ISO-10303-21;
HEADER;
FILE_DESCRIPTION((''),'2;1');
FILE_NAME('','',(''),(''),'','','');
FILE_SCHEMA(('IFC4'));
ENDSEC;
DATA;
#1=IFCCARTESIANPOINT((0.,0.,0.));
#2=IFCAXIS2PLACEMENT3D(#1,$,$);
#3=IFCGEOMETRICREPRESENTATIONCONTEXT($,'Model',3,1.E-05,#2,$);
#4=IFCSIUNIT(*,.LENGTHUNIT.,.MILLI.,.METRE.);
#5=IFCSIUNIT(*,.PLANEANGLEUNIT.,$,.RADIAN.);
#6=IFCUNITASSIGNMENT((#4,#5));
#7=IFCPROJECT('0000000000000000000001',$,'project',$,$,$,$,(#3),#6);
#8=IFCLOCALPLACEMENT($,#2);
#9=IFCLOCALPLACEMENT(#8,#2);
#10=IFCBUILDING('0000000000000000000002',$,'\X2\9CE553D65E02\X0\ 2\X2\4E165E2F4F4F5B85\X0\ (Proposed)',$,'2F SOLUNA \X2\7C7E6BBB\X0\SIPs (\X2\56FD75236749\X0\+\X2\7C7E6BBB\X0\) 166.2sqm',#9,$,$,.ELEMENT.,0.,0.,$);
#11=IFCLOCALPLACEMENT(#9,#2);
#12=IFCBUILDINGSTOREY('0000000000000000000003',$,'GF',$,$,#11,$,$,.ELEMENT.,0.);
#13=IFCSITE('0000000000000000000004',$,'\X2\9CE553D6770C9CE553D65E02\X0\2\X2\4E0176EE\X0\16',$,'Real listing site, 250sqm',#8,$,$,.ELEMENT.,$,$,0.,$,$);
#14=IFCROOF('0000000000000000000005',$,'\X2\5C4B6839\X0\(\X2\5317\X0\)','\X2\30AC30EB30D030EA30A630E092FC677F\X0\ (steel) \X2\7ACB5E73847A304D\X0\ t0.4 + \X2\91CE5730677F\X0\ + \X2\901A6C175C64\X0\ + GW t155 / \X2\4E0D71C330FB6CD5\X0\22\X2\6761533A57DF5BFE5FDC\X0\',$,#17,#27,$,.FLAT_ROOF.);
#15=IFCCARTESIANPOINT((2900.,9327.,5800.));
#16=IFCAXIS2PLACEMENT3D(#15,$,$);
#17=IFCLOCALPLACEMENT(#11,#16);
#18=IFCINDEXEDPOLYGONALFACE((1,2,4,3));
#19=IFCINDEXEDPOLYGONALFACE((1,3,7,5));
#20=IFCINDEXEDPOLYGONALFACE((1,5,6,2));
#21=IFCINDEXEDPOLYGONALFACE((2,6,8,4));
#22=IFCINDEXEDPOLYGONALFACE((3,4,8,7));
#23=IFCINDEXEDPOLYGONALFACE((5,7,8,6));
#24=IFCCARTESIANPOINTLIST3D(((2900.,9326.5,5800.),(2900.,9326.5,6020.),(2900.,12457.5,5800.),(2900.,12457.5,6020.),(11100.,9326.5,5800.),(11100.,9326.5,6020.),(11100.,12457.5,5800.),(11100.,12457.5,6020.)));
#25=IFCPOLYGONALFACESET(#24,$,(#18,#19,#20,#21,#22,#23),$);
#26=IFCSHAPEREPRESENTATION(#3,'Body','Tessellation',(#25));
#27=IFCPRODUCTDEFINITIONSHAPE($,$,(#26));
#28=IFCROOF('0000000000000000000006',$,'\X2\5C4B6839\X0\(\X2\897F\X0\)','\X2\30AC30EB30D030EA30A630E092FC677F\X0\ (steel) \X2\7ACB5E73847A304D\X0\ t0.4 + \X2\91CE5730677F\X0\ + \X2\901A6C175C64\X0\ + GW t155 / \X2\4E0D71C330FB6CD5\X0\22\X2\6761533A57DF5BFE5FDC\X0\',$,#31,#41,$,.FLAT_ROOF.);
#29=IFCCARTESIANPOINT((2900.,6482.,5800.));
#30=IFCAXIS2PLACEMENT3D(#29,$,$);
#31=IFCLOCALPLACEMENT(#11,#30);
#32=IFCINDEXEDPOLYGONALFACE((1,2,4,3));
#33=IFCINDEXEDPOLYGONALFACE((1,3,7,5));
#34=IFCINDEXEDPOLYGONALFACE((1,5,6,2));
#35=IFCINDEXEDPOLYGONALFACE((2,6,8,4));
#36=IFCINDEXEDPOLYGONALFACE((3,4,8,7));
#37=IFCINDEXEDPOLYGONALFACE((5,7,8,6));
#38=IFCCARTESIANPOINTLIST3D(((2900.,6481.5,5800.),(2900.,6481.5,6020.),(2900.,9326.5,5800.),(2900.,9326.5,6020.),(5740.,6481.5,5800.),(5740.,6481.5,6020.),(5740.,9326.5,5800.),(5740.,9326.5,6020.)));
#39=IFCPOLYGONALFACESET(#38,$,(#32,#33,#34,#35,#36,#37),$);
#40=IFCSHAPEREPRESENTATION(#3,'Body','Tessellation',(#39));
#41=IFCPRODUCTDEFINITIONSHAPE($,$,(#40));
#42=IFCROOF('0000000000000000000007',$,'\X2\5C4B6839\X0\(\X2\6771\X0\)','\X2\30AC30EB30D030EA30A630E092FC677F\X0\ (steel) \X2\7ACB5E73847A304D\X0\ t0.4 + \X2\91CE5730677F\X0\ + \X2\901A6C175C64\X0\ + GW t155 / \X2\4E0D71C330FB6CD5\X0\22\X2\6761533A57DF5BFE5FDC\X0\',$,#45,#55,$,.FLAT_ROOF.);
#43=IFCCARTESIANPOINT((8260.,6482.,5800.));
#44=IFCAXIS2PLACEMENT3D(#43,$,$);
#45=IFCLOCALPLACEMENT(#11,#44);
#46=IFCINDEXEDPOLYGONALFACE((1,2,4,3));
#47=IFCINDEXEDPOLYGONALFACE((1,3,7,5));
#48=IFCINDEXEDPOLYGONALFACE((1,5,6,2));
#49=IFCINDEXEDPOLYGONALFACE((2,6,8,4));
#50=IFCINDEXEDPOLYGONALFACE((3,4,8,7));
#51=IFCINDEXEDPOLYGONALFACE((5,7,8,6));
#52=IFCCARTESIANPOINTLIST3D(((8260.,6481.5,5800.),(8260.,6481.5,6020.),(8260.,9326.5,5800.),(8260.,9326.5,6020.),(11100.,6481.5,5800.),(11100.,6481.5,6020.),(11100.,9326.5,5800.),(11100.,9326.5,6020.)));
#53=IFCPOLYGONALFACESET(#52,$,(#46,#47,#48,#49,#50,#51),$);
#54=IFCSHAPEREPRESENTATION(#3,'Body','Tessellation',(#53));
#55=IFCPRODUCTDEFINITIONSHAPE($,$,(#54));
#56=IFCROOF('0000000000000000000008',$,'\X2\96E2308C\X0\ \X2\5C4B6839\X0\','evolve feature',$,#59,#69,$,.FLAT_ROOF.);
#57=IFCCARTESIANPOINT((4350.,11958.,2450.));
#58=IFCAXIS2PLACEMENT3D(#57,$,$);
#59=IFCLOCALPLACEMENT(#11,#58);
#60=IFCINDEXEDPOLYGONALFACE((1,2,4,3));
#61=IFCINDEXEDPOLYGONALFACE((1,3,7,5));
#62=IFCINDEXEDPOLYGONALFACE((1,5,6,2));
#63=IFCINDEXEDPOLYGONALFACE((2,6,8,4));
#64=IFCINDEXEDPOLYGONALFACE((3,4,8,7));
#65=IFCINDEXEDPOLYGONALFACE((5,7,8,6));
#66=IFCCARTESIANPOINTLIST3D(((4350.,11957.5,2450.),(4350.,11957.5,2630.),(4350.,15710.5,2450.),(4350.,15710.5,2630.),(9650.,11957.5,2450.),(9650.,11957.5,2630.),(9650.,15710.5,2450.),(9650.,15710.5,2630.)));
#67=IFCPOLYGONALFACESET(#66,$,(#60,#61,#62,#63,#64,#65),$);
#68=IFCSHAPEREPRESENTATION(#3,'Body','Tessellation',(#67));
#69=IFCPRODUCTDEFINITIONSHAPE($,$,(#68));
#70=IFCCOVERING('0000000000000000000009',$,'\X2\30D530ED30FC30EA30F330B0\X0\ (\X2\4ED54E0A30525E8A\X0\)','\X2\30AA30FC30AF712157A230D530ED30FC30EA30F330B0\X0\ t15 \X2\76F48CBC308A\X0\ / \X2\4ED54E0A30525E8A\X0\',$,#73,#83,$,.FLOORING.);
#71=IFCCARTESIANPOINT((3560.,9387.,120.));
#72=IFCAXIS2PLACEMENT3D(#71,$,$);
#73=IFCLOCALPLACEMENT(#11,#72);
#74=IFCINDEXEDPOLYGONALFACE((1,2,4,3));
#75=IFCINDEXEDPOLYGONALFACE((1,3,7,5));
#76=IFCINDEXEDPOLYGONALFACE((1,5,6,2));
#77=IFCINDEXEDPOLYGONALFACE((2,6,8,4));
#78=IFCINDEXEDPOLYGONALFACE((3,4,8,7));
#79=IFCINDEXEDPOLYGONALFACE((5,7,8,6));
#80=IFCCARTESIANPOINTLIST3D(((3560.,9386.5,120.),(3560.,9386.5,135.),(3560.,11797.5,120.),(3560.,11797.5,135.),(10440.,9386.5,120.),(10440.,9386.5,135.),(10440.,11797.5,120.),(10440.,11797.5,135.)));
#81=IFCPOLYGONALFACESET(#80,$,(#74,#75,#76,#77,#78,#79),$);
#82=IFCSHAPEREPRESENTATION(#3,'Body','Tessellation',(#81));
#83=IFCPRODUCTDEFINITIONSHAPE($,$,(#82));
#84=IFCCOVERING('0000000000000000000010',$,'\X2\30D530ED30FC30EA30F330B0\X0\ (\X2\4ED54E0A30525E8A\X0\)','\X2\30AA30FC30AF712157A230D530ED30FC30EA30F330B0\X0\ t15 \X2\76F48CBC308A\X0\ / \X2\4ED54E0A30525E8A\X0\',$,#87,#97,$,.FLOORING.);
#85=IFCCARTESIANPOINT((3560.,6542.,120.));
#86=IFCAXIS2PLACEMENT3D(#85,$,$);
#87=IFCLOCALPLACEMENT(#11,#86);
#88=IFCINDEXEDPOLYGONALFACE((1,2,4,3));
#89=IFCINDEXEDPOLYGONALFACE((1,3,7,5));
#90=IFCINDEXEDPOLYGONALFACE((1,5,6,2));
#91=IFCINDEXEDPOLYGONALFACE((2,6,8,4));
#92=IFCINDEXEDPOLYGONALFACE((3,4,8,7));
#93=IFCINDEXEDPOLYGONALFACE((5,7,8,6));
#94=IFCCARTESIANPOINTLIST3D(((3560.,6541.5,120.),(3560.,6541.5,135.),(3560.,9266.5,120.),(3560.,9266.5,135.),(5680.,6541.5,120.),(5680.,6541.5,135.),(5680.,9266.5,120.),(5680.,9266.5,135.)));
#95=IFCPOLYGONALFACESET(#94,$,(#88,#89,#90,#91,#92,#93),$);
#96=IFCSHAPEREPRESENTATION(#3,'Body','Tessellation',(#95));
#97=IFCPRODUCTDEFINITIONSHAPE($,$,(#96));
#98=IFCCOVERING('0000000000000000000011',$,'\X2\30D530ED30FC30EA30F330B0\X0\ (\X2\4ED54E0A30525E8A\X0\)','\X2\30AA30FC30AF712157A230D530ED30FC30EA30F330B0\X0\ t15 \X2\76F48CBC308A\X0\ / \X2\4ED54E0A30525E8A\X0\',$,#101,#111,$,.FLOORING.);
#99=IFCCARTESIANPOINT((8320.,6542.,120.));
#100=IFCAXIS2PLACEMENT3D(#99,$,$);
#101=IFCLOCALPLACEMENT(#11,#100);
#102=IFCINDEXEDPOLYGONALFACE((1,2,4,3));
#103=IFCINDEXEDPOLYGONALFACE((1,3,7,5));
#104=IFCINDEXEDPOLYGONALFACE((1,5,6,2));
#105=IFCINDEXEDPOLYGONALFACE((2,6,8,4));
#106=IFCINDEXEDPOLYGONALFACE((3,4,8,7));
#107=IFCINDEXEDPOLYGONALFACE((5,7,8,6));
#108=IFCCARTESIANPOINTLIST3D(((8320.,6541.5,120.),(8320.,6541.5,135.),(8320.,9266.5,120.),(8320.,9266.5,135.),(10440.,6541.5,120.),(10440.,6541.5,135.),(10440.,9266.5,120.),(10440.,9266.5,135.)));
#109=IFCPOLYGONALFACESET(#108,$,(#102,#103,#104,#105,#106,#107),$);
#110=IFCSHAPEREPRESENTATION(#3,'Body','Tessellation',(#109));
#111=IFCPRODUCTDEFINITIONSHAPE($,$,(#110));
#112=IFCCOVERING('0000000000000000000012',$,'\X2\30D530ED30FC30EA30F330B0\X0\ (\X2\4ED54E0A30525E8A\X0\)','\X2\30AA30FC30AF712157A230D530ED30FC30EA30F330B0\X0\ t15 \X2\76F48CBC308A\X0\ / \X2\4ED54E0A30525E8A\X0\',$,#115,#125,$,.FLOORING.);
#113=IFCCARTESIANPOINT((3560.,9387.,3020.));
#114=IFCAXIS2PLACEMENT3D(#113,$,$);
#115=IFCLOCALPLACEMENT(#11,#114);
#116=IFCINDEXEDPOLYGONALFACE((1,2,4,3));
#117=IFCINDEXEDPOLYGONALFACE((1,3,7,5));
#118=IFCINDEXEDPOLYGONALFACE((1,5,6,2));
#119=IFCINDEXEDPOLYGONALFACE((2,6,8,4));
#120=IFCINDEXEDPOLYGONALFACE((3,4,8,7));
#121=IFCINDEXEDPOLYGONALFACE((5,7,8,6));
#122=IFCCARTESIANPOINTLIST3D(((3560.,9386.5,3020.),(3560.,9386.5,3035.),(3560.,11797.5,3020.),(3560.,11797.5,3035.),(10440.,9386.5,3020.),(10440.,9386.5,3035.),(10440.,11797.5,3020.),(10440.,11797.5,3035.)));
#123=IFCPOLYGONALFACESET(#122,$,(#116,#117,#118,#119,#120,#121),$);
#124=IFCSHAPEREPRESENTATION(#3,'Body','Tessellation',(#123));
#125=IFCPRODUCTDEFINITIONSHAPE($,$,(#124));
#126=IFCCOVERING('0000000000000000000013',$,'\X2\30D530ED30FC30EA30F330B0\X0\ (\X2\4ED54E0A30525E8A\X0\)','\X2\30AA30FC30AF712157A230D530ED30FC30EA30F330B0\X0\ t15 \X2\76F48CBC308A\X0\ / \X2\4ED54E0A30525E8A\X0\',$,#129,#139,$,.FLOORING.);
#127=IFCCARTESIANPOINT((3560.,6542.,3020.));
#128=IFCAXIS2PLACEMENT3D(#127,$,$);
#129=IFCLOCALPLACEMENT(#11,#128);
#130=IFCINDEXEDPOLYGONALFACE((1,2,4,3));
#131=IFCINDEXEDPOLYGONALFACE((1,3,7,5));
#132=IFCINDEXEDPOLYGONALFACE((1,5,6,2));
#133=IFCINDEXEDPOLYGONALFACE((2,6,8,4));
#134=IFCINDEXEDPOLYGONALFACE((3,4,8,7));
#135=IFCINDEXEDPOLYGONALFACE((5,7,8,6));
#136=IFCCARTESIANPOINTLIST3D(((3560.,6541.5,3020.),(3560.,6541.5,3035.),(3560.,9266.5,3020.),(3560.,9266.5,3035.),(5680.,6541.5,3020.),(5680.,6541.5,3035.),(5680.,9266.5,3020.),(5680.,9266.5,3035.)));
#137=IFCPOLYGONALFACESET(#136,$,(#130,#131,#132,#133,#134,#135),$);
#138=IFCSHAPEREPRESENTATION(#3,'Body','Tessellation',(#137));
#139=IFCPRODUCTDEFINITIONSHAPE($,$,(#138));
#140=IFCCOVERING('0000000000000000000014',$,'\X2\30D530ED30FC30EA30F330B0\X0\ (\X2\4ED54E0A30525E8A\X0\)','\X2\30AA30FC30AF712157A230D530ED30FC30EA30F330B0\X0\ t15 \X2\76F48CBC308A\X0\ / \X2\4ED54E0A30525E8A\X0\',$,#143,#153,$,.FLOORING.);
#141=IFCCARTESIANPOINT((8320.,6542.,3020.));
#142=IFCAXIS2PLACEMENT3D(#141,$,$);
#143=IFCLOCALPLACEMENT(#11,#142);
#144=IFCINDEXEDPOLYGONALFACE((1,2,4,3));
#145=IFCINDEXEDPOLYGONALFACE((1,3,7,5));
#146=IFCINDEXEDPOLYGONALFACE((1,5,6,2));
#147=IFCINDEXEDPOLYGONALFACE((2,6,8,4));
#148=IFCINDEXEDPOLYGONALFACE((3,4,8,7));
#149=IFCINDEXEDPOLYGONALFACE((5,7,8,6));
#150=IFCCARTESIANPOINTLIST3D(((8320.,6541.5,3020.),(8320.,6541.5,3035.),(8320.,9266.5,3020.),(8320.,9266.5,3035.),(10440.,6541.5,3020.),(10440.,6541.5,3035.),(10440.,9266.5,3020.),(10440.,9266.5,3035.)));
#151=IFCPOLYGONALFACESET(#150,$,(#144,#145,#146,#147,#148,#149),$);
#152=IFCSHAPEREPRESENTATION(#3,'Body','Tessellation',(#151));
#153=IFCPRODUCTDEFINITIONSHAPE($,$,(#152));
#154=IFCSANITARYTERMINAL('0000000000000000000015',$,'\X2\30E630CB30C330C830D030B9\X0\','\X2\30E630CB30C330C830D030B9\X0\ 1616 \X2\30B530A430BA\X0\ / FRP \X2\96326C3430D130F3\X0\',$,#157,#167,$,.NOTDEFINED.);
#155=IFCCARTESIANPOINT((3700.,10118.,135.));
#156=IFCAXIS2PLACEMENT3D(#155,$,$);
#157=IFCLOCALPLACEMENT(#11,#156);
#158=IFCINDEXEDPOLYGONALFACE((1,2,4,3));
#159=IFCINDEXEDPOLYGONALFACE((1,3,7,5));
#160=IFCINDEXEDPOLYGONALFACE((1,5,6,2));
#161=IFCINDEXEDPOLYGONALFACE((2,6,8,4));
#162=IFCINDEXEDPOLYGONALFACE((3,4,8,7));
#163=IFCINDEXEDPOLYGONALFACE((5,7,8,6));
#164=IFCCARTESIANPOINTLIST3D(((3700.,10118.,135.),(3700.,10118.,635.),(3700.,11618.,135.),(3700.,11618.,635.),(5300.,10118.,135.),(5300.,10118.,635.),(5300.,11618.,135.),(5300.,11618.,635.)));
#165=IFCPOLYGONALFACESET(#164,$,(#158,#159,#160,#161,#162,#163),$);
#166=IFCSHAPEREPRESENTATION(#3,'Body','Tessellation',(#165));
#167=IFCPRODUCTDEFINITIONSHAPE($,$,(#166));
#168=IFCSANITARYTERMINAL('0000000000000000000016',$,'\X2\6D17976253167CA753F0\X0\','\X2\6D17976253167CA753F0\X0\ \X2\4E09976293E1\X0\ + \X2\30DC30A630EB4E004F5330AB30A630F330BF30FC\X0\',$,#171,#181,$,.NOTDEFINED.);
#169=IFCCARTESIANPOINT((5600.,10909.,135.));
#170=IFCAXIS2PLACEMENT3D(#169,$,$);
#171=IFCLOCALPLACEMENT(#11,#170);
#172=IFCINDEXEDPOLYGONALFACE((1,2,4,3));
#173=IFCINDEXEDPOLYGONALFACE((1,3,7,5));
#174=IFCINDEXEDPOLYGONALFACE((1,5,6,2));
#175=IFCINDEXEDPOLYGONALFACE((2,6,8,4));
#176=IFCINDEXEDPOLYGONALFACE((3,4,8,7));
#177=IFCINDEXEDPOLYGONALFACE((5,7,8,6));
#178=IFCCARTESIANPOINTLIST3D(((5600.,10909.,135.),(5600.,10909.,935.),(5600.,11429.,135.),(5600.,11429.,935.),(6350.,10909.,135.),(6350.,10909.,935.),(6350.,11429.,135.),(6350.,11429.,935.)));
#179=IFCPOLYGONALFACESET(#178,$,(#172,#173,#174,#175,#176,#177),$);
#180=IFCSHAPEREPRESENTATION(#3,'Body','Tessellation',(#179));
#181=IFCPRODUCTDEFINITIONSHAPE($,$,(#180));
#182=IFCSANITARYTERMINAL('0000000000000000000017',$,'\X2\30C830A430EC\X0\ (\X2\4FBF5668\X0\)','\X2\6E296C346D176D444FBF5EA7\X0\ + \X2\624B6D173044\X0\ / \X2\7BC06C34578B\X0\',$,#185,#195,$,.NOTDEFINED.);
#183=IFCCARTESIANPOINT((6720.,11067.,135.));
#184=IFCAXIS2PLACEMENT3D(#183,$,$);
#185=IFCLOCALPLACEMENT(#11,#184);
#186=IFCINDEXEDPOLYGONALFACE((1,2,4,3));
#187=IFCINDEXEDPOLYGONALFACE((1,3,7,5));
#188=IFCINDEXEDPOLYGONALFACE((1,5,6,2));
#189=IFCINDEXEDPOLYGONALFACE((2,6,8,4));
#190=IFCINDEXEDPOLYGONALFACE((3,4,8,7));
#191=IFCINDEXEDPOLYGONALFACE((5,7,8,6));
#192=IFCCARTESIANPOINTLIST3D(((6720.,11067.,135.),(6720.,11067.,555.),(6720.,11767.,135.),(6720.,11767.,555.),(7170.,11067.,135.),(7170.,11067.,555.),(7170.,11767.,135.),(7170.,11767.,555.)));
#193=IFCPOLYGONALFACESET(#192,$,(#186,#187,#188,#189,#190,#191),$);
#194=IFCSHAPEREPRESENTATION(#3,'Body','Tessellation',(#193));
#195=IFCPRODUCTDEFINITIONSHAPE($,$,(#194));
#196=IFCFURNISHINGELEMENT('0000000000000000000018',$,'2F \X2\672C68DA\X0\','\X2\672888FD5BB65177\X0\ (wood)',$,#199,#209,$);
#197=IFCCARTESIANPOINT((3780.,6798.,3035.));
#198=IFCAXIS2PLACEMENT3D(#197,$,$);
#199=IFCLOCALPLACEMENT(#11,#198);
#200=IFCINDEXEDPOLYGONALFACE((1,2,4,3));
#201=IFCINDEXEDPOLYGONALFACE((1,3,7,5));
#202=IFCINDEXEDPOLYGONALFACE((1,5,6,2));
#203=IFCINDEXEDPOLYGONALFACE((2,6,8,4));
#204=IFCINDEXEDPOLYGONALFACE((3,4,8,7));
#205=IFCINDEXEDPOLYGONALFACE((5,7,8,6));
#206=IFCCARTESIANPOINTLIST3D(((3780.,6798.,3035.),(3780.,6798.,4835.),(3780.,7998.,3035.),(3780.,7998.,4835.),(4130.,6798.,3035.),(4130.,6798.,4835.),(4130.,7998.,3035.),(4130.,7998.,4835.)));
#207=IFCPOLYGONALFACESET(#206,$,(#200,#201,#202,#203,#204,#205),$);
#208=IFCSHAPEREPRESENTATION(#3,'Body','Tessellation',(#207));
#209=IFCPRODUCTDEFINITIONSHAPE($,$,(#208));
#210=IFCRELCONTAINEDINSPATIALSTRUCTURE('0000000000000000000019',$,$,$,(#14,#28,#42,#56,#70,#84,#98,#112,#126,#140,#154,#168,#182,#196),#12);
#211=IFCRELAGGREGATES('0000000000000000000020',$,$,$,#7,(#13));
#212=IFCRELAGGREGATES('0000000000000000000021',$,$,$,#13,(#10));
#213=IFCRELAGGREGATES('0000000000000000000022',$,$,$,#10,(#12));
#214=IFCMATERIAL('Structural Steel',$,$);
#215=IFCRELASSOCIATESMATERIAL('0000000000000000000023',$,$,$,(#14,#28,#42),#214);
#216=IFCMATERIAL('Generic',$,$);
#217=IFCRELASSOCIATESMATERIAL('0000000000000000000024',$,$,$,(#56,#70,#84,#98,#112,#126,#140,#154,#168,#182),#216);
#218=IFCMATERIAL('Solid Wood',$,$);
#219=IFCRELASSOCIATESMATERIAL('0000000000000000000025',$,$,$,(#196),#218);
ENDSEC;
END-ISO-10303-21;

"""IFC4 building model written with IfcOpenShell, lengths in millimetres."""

from ifc_helpers import new_model, si_unit, frame, frame_2d, origin, place, context, project, spatial, rectangle, extrude, material, element, save


model = new_model("IFC4")

# Units and contexts
model_context = context("Model", 3, precision=1e-05, world=origin())
ifc_project = project(units=[si_unit("LENGTHUNIT", "METRE", prefix="MILLI"), si_unit("PLANEANGLEUNIT", "RADIAN")], contexts=[model_context])

# Site, building, storey
site_placement = place(None, origin())
site = spatial("IfcSite", under=ifc_project, at=site_placement, Name="鳥取県鳥取市2丁目16", ObjectType="Real listing site, 250sqm", CompositionType="ELEMENT", RefElevation=0.0)
building_placement = place(site_placement, origin())
building = spatial("IfcBuilding", under=site, at=building_placement, Name="鳥取市 2世帯住宅 (Proposed)", ObjectType="2F SOLUNA 籾殻SIPs (国産杉+籾殻) 166.2sqm", CompositionType="ELEMENT", ElevationOfRefHeight=0.0, ElevationOfTerrain=0.0)
storey_placement = place(building_placement, origin())
storey = spatial("IfcBuildingStorey", under=building, at=storey_placement, Name="GF", CompositionType="ELEMENT", Elevation=0.0)

# Shared definitions
ifc_material_1 = material(Name="Solid Wood")
ifc_material_2 = material(Name="Generic")

# Roofs
ifc_material_3 = material(Name="Structural Steel")
for number, where, name in (
    (1, (2900.0, 9327.0, 5800.0), "屋根(北)"),
):
    element("IfcRoof", number, at=place(storey_placement, frame(where)), inside=storey, material=ifc_material_3, Name=name, Description="ガルバリウム鋼板 (steel) 立平葺き t0.4 + 野地板 + 通気層 + GW t155 / 不燃・法22条区域対応", PredefinedType="FLAT_ROOF", context=model_context, shape_type="SweptSolid", body=[
        extrude(rectangle(XDim=8200.0, YDim=3131.0, at=frame_2d((4100.0, 1565.0))), frame((2900.0, 9327.0, 5800.0)), (0.0, 0.0, 1.0), 220.0),
    ])
roof_1_placement = place(storey_placement, frame((2900.0, 6482.0, 5800.0)))
element("IfcRoof", 2, at=roof_1_placement, inside=storey, material=ifc_material_3, Name="屋根(西)", Description="ガルバリウム鋼板 (steel) 立平葺き t0.4 + 野地板 + 通気層 + GW t155 / 不燃・法22条区域対応", PredefinedType="FLAT_ROOF", context=model_context, shape_type="SweptSolid", body=[
    extrude(rectangle(XDim=2840.0, YDim=2845.0, at=frame_2d((1420.0, 1422.0))), frame((2900.0, 6482.0, 5800.0)), (0.0, 0.0, 1.0), 220.0),
])
roof_2_placement = place(storey_placement, frame((8260.0, 6482.0, 5800.0)))
element("IfcRoof", 3, at=roof_2_placement, inside=storey, material=ifc_material_3, Name="屋根(東)", Description="ガルバリウム鋼板 (steel) 立平葺き t0.4 + 野地板 + 通気層 + GW t155 / 不燃・法22条区域対応", PredefinedType="FLAT_ROOF", context=model_context, shape_type="SweptSolid", body=[
    extrude(rectangle(XDim=2840.0, YDim=2845.0, at=frame_2d((1420.0, 1422.0))), frame((8260.0, 6482.0, 5800.0)), (0.0, 0.0, 1.0), 220.0),
])
roof_3_placement = place(storey_placement, frame((4350.0, 11958.0, 2450.0)))
element("IfcRoof", 4, at=roof_3_placement, inside=storey, material=ifc_material_2, Name="離れ 屋根", Description="evolve feature", PredefinedType="FLAT_ROOF", context=model_context, shape_type="SweptSolid", body=[
    extrude(rectangle(XDim=5300.0, YDim=3753.0, at=frame_2d((2650.0, 1876.0))), frame((4350.0, 11958.0, 2450.0)), (0.0, 0.0, 1.0), 180.0),
])

# Coverings
covering_1_placement = place(storey_placement, frame((3560.0, 9387.0, 120.0)))
element("IfcCovering", 5, at=covering_1_placement, inside=storey, material=ifc_material_2, Name="フローリング (仕上げ床)", Description="オーク無垢フローリング t15 直貼り / 仕上げ床", PredefinedType="FLOORING", context=model_context, shape_type="SweptSolid", body=[
    extrude(rectangle(XDim=6880.0, YDim=2411.0, at=frame_2d((3440.0, 1205.0))), frame((3560.0, 9387.0, 120.0)), (0.0, 0.0, 1.0), 15.0),
])
covering_2_placement = place(storey_placement, frame((3560.0, 6542.0, 120.0)))
element("IfcCovering", 6, at=covering_2_placement, inside=storey, material=ifc_material_2, Name="フローリング (仕上げ床)", Description="オーク無垢フローリング t15 直貼り / 仕上げ床", PredefinedType="FLOORING", context=model_context, shape_type="SweptSolid", body=[
    extrude(rectangle(XDim=2120.0, YDim=2725.0, at=frame_2d((1060.0, 1362.0))), frame((3560.0, 6542.0, 120.0)), (0.0, 0.0, 1.0), 15.0),
])
covering_3_placement = place(storey_placement, frame((8320.0, 6542.0, 120.0)))
element("IfcCovering", 7, at=covering_3_placement, inside=storey, material=ifc_material_2, Name="フローリング (仕上げ床)", Description="オーク無垢フローリング t15 直貼り / 仕上げ床", PredefinedType="FLOORING", context=model_context, shape_type="SweptSolid", body=[
    extrude(rectangle(XDim=2120.0, YDim=2725.0, at=frame_2d((1060.0, 1362.0))), frame((8320.0, 6542.0, 120.0)), (0.0, 0.0, 1.0), 15.0),
])
covering_4_placement = place(storey_placement, frame((3560.0, 9387.0, 3020.0)))
element("IfcCovering", 8, at=covering_4_placement, inside=storey, material=ifc_material_2, Name="フローリング (仕上げ床)", Description="オーク無垢フローリング t15 直貼り / 仕上げ床", PredefinedType="FLOORING", context=model_context, shape_type="SweptSolid", body=[
    extrude(rectangle(XDim=6880.0, YDim=2411.0, at=frame_2d((3440.0, 1205.0))), frame((3560.0, 9387.0, 3020.0)), (0.0, 0.0, 1.0), 15.0),
])
covering_5_placement = place(storey_placement, frame((3560.0, 6542.0, 3020.0)))
element("IfcCovering", 9, at=covering_5_placement, inside=storey, material=ifc_material_2, Name="フローリング (仕上げ床)", Description="オーク無垢フローリング t15 直貼り / 仕上げ床", PredefinedType="FLOORING", context=model_context, shape_type="SweptSolid", body=[
    extrude(rectangle(XDim=2120.0, YDim=2725.0, at=frame_2d((1060.0, 1362.0))), frame((3560.0, 6542.0, 3020.0)), (0.0, 0.0, 1.0), 15.0),
])
covering_6_placement = place(storey_placement, frame((8320.0, 6542.0, 3020.0)))
element("IfcCovering", 10, at=covering_6_placement, inside=storey, material=ifc_material_2, Name="フローリング (仕上げ床)", Description="オーク無垢フローリング t15 直貼り / 仕上げ床", PredefinedType="FLOORING", context=model_context, shape_type="SweptSolid", body=[
    extrude(rectangle(XDim=2120.0, YDim=2725.0, at=frame_2d((1060.0, 1362.0))), frame((8320.0, 6542.0, 3020.0)), (0.0, 0.0, 1.0), 15.0),
])

# Sanitary terminals
sanitary_terminal_1_placement = place(storey_placement, frame((3700.0, 10118.0, 135.0)))
element("IfcSanitaryTerminal", 11, at=sanitary_terminal_1_placement, inside=storey, material=ifc_material_2, Name="ユニットバス", Description="ユニットバス 1616 サイズ / FRP 防水パン", PredefinedType="NOTDEFINED", context=model_context, shape_type="SweptSolid", body=[
    extrude(rectangle(XDim=1600.0, YDim=1500.0, at=frame_2d((800.0, 750.0))), frame((3700.0, 10118.0, 135.0)), (0.0, 0.0, 1.0), 500.0),
])
sanitary_terminal_2_placement = place(storey_placement, frame((5600.0, 10909.0, 135.0)))
element("IfcSanitaryTerminal", 12, at=sanitary_terminal_2_placement, inside=storey, material=ifc_material_2, Name="洗面化粧台", Description="洗面化粧台 三面鏡 + ボウル一体カウンター", PredefinedType="NOTDEFINED", context=model_context, shape_type="SweptSolid", body=[
    extrude(rectangle(XDim=750.0, YDim=520.0, at=frame_2d((375.0, 260.0))), frame((5600.0, 10909.0, 135.0)), (0.0, 0.0, 1.0), 800.0),
])
sanitary_terminal_3_placement = place(storey_placement, frame((6720.0, 11067.0, 135.0)))
element("IfcSanitaryTerminal", 13, at=sanitary_terminal_3_placement, inside=storey, material=ifc_material_2, Name="トイレ (便器)", Description="温水洗浄便座 + 手洗い / 節水型", PredefinedType="NOTDEFINED", context=model_context, shape_type="SweptSolid", body=[
    extrude(rectangle(XDim=450.0, YDim=700.0, at=frame_2d((225.0, 350.0))), frame((6720.0, 11067.0, 135.0)), (0.0, 0.0, 1.0), 420.0),
])

# Furnishing element
furnishing_placement = place(storey_placement, frame((3780.0, 6798.0, 3035.0)))
element("IfcFurnishingElement", 14, at=furnishing_placement, inside=storey, material=ifc_material_1, Name="2F 本棚", Description="木製家具 (wood)", context=model_context, shape_type="SweptSolid", body=[
    extrude(rectangle(XDim=350.0, YDim=1200.0, at=frame_2d((175.0, 600.0))), frame((3780.0, 6798.0, 3035.0)), (0.0, 0.0, 1.0), 1800.0),
])

save(model, "model.ifc")
